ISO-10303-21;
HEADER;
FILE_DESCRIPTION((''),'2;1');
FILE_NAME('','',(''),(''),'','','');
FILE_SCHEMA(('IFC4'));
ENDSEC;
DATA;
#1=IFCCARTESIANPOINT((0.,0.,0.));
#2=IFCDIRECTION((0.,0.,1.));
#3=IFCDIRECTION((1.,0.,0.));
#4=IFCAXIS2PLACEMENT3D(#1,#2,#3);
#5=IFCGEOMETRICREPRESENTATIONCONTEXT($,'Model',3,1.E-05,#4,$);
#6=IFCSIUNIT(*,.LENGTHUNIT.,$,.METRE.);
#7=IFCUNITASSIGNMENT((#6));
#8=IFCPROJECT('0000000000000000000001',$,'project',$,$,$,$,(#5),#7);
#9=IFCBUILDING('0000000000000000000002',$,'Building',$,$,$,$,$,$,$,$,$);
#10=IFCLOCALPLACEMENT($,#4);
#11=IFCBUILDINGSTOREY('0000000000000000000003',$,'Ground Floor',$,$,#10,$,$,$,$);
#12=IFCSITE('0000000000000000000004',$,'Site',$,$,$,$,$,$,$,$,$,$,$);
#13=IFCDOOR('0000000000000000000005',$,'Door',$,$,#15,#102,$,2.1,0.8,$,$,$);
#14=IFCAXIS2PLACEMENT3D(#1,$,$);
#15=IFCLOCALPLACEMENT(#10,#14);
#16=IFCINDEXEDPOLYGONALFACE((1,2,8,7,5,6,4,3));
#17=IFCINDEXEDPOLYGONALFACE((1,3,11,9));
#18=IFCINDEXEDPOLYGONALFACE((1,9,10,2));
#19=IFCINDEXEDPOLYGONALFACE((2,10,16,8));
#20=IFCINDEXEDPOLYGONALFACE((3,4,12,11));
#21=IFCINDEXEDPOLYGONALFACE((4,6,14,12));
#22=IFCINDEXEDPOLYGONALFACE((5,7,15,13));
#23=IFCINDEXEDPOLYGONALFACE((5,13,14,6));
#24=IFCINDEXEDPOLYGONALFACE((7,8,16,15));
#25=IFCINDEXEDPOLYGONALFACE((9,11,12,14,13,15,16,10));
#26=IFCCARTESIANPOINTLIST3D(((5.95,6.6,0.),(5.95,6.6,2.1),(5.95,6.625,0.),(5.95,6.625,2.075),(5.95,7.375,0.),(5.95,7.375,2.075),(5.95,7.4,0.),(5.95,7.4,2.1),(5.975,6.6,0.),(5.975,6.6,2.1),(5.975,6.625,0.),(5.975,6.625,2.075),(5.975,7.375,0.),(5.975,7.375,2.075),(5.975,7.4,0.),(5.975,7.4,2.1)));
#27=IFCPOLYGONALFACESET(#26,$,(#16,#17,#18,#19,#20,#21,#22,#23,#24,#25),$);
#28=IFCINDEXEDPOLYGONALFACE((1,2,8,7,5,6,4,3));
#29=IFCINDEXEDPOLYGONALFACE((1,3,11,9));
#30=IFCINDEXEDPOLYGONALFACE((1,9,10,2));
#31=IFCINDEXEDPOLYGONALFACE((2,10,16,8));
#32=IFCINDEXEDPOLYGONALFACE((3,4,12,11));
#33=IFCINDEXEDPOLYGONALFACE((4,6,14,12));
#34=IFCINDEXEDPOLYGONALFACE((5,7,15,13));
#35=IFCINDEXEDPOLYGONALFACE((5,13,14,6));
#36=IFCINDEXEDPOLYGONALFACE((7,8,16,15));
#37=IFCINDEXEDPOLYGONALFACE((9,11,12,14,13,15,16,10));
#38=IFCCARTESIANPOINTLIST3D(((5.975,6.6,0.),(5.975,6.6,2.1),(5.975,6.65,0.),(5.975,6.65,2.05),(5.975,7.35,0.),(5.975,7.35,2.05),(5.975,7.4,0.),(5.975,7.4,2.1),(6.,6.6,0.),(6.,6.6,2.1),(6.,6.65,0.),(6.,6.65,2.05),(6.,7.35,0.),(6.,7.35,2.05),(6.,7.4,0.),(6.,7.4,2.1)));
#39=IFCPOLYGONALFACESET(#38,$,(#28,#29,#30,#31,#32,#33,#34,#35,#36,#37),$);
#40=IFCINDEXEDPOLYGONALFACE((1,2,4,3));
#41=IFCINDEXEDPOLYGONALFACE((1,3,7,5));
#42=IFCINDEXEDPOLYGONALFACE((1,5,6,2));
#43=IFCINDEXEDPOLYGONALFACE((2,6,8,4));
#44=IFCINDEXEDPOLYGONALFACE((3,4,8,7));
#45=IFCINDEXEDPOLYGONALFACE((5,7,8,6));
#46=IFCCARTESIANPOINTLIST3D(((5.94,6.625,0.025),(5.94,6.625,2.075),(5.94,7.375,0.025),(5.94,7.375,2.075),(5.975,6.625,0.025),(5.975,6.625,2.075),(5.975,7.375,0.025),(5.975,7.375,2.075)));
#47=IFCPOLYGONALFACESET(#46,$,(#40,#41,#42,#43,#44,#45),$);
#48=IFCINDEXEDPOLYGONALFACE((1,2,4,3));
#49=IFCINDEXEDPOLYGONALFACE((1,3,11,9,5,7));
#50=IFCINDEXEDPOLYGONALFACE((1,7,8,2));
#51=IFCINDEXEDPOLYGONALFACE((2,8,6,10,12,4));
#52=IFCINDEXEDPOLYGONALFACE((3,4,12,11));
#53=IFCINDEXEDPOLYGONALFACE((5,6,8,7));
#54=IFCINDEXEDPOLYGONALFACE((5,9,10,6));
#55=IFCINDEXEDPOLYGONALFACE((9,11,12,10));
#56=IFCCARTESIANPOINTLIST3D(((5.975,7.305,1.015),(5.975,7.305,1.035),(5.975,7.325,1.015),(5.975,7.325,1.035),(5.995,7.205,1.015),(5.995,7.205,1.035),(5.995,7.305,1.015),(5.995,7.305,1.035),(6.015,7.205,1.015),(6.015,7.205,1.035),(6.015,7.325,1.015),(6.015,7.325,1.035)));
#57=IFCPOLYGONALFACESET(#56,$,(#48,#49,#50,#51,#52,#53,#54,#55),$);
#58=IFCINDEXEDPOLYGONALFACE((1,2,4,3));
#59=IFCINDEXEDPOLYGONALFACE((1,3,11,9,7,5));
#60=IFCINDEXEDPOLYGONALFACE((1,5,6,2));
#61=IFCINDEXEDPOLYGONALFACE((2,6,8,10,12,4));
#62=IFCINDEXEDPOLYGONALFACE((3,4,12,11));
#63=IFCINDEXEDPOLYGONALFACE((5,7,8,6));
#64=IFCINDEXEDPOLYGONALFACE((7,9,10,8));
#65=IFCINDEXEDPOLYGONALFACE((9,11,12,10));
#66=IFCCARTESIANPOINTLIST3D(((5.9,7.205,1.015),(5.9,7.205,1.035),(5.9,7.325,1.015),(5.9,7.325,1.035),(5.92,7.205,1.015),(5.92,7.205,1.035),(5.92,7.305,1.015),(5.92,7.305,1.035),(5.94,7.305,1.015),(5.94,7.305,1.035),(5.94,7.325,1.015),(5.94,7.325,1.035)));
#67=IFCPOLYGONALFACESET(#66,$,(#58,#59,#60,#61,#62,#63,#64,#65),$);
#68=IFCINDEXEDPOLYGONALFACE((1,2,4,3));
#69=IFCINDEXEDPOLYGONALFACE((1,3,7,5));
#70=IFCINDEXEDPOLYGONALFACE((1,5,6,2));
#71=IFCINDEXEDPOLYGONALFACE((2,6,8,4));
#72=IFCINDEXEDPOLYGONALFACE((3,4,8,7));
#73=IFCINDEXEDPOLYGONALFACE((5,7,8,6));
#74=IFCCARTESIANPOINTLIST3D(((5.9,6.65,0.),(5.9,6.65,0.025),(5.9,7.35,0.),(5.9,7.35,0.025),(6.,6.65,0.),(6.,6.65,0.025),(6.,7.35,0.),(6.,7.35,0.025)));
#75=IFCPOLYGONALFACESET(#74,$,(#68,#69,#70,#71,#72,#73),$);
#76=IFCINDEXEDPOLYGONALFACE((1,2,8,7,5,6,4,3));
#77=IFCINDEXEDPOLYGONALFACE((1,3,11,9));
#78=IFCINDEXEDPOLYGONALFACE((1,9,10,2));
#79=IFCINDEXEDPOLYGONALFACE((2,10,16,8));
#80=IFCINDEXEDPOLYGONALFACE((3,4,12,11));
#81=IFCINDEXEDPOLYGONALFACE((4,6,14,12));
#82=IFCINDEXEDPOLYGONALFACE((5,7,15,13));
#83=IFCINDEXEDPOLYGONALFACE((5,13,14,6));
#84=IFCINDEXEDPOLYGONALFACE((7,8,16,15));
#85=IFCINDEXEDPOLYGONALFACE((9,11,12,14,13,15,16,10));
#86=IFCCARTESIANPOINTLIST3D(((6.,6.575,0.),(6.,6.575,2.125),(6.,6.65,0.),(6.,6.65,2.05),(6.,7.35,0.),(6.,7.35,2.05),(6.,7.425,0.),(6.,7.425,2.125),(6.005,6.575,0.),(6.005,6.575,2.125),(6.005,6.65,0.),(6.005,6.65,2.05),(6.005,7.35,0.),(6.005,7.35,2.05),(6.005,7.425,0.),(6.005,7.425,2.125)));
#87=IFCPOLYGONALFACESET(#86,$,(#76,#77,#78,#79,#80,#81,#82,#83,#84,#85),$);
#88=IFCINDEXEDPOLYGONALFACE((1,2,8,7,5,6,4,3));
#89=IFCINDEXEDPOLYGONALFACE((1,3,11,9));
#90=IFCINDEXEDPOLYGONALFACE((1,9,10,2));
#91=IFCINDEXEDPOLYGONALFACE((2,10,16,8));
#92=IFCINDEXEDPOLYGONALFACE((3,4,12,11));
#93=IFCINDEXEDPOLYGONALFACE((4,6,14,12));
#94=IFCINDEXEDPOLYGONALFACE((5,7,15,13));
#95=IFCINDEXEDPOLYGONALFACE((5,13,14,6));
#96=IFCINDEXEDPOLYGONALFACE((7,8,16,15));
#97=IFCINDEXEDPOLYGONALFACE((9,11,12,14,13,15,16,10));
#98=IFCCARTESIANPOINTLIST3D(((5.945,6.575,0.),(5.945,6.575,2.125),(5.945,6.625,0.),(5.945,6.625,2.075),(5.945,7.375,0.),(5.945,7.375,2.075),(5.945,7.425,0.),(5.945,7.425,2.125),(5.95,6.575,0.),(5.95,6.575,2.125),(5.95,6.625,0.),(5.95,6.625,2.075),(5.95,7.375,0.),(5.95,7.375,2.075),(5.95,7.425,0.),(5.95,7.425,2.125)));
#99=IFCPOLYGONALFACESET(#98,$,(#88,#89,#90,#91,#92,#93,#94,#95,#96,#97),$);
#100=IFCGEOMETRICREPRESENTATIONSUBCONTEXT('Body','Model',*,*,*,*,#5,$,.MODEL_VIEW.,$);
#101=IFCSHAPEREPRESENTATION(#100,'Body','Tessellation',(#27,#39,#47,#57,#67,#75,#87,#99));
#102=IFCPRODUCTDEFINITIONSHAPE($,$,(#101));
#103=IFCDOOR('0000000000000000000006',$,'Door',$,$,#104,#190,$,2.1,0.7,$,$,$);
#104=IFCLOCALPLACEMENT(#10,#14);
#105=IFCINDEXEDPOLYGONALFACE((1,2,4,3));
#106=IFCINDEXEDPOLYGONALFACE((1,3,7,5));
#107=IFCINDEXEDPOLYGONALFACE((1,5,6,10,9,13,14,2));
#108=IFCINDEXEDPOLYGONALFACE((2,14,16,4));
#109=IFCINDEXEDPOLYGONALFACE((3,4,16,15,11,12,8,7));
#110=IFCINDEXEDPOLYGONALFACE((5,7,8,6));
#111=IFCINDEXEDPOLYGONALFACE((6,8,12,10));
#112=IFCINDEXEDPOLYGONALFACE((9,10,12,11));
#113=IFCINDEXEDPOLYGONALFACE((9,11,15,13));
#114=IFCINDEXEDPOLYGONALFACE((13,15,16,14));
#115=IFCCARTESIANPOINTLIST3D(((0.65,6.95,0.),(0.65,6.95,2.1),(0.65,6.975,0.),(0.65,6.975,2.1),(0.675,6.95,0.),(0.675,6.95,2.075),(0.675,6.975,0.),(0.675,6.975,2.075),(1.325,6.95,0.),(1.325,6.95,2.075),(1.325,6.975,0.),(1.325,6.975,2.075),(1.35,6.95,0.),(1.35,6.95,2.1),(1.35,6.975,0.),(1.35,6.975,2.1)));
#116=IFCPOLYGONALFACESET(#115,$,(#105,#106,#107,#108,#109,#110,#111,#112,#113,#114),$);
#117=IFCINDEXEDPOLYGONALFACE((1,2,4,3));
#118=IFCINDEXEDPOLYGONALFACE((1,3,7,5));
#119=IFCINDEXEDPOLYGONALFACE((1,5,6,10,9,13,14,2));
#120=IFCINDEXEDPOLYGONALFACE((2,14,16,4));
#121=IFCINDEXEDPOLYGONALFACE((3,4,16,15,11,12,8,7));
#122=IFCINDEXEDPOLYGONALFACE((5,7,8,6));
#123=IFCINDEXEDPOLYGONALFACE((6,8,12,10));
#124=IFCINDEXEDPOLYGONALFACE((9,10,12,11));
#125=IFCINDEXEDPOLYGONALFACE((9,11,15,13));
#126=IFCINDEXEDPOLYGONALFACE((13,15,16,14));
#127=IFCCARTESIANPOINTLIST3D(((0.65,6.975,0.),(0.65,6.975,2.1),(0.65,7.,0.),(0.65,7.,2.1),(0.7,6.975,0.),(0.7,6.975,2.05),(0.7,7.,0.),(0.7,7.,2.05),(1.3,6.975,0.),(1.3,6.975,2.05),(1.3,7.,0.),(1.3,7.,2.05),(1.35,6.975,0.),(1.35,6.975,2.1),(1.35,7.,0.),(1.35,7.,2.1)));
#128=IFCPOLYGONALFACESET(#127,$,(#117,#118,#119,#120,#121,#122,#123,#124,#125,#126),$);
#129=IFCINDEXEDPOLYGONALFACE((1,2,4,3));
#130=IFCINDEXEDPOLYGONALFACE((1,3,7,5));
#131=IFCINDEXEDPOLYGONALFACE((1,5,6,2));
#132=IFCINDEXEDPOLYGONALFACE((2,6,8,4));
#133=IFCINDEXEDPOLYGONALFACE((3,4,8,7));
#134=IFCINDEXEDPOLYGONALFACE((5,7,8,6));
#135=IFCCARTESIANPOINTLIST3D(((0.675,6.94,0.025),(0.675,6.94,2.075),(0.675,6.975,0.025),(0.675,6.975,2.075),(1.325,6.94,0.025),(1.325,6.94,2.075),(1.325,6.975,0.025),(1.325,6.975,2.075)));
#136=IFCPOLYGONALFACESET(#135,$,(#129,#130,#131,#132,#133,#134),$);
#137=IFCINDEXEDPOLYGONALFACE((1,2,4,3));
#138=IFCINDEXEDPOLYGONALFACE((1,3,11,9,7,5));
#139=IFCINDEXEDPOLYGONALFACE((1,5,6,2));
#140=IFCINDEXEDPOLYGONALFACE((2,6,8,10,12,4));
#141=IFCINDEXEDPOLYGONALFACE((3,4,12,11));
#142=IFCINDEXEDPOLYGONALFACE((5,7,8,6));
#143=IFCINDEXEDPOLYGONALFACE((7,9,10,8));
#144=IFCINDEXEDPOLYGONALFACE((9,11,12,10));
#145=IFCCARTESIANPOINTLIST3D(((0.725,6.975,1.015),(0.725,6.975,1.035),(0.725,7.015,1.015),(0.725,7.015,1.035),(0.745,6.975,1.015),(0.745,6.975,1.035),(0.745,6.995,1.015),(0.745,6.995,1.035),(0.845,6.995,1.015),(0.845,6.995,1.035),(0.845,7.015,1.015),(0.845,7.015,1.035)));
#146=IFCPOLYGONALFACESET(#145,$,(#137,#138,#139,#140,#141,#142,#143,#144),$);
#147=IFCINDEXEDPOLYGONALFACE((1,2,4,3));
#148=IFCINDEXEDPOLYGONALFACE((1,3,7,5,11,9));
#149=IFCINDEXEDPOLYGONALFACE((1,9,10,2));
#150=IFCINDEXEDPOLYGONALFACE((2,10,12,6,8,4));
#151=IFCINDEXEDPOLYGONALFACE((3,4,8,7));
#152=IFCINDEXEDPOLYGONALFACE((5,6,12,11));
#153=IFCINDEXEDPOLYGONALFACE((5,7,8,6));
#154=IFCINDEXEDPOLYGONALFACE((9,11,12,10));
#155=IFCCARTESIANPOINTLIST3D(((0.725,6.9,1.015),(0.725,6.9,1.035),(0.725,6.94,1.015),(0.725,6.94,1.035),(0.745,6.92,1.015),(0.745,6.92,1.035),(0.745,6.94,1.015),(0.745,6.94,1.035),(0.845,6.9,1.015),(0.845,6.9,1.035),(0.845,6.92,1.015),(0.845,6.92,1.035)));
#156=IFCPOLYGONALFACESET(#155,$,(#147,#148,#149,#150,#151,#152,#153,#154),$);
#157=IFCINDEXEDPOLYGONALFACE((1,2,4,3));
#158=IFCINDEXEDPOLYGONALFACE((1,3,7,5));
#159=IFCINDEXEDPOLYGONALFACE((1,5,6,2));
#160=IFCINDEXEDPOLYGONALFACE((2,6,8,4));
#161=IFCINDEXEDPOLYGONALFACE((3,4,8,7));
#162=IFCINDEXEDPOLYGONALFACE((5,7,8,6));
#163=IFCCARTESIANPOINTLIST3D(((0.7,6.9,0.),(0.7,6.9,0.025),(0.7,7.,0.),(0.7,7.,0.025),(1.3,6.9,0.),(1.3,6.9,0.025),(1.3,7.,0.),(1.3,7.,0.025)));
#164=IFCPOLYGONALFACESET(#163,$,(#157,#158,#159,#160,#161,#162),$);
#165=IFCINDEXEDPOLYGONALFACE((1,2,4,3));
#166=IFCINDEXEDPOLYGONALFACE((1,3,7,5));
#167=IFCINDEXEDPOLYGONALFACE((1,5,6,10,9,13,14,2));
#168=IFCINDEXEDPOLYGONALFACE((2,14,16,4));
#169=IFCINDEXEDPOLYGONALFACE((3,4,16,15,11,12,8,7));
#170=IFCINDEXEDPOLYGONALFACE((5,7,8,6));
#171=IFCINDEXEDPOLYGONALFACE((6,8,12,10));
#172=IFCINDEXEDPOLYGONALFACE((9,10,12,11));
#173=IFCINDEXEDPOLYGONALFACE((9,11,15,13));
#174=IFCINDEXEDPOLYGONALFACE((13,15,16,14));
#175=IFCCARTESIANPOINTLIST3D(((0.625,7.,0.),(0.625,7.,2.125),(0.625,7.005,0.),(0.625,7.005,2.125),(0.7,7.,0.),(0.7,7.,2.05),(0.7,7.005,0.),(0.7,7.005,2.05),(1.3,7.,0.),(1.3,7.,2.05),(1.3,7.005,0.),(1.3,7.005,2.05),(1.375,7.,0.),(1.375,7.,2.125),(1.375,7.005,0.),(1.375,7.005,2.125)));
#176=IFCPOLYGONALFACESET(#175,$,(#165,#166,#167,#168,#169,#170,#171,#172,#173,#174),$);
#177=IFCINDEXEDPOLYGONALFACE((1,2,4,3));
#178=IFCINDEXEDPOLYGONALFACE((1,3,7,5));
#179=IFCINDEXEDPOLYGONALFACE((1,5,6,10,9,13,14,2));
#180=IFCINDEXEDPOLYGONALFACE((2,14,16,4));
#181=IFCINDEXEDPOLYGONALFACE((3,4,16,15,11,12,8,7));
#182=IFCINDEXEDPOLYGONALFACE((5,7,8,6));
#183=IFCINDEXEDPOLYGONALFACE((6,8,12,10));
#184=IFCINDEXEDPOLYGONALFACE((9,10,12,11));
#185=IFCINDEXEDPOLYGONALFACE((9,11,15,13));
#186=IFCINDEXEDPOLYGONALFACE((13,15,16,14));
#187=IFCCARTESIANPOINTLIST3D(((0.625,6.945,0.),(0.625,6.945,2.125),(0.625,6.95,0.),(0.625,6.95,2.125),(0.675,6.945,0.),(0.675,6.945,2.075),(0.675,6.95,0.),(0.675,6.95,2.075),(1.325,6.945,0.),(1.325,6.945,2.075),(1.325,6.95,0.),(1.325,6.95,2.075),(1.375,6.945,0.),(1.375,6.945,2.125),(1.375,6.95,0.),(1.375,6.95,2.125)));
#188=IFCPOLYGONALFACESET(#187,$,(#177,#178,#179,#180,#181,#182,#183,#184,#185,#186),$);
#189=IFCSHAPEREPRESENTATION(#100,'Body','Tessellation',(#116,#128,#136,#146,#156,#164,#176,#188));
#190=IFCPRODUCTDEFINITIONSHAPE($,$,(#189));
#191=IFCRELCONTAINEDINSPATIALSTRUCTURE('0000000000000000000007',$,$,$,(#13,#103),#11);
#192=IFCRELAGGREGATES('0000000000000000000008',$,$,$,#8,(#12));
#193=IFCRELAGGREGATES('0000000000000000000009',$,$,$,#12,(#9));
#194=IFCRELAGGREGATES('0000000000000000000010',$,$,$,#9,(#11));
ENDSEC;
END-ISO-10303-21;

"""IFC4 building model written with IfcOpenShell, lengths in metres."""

from ifc_helpers import new_model, si_unit, frame, origin_with_axes, place, context, subcontext, project, spatial, line, indexed_curve, outline, extrude, element, save


model = new_model("IFC4")

# Units and contexts
model_context = context("Model", 3, precision=1e-05, world=origin_with_axes())
body_context = subcontext(model_context, "Body", "Model", "MODEL_VIEW")
ifc_project = project(units=[si_unit("LENGTHUNIT", "METRE")], contexts=[model_context])

# Site, building, storey
site = spatial("IfcSite", under=ifc_project, Name="Site")
building = spatial("IfcBuilding", under=site, Name="Building")
storey_placement = place(None, origin_with_axes())
storey = spatial("IfcBuildingStorey", under=building, at=storey_placement, Name="Ground Floor")

# Doors
door_1_placement = place(storey_placement, frame((6.0, 6.6, 0.0), z_axis=(0.0, 0.0, 1.0), x_axis=(0.0, 1.0, 0.0)))
element("IfcDoor", 1, at=door_1_placement, inside=storey, Name="Door", OverallHeight=2.1, OverallWidth=0.8, context=body_context, shape_type="SweptSolid", body=[
    extrude(outline(indexed_curve([(0.0, 0.0), (0.0, 2.1), (0.8, 2.1), (0.8, 0.0), (0.775, 0.0), (0.775, 2.075), (0.025, 2.075), (0.025, 0.0)], segments=[line(1, 2, 3, 4, 5, 6, 7, 8, 1)])), frame((0.0, 0.025, 0.0), z_axis=(0.0, -1.0, 0.0), x_axis=(1.0, 0.0, 0.0)), (0.0, 0.0, -1.0), 0.025),
    extrude(outline(indexed_curve([(0.0, 0.0), (0.0, 2.1), (0.8, 2.1), (0.8, 0.0), (0.75, 0.0), (0.75, 2.05), (0.05, 2.05), (0.05, 0.0)], segments=[line(1, 2, 3, 4, 5, 6, 7, 8, 1)])), frame((0.0, 0.0, 0.0), z_axis=(0.0, -1.0, 0.0), x_axis=(1.0, 0.0, 0.0)), (0.0, 0.0, -1.0), 0.025),
    extrude(outline(indexed_curve([(0.0, 0.0), (0.75, 0.0), (0.75, 0.035), (0.0, 0.035)], segments=[line(1, 2, 3, 4, 1)])), frame((0.025, 0.025, 0.025), z_axis=(0.0, 0.0, 1.0), x_axis=(1.0, 0.0, 0.0)), (0.0, 0.0, 1.0), 2.05),
    extrude(outline(indexed_curve([(0.0, 0.0), (0.0, -0.04), (-0.12, -0.04), (-0.12, -0.02), (-0.02, -0.02), (-0.02, 0.0)], segments=[line(1, 2, 3, 4, 5, 6, 1)])), frame((0.725, 0.025, 1.015), z_axis=(0.0, 0.0, 1.0), x_axis=(1.0, 0.0, 0.0)), (0.0, 0.0, 1.0), 0.02),
    extrude(outline(indexed_curve([(0.0, 0.0), (0.0, 0.04), (-0.12, 0.04), (-0.12, 0.02), (-0.02, 0.02), (-0.02, 0.0)], segments=[line(1, 2, 3, 4, 5, 6, 1)])), frame((0.725, 0.06, 1.015), z_axis=(0.0, 0.0, 1.0), x_axis=(1.0, 0.0, 0.0)), (0.0, 0.0, 1.0), 0.02),
    extrude(outline(indexed_curve([(0.0, 0.0), (0.7, 0.0), (0.7, 0.1), (0.0, 0.1)], segments=[line(1, 2, 3, 4, 1)])), frame((0.05, 0.0, 0.0), z_axis=(0.0, 0.0, 1.0), x_axis=(1.0, 0.0, 0.0)), (0.0, 0.0, 1.0), 0.025),
    extrude(outline(indexed_curve([(0.0, 0.0), (0.0, 2.125), (0.85, 2.125), (0.85, 0.0), (0.775, 0.0), (0.775, 2.05), (0.075, 2.05), (0.075, 0.0)], segments=[line(1, 2, 3, 4, 5, 6, 7, 8, 1)])), frame((-0.025, -0.005, 0.0), z_axis=(0.0, -1.0, 0.0), x_axis=(1.0, 0.0, 0.0)), (0.0, 0.0, -1.0), 0.005),
    extrude(outline(indexed_curve([(0.0, 0.0), (0.0, 2.125), (0.85, 2.125), (0.85, 0.0), (0.8, 0.0), (0.8, 2.075), (0.05, 2.075), (0.05, 0.0)], segments=[line(1, 2, 3, 4, 5, 6, 7, 8, 1)])), frame((-0.025, 0.05, 0.0), z_axis=(0.0, -1.0, 0.0), x_axis=(1.0, 0.0, 0.0)), (0.0, 0.0, -1.0), 0.005),
])
door_2_placement = place(storey_placement, frame((1.35, 7.0, 0.0), z_axis=(0.0, 0.0, 1.0), x_axis=(-1.0, 0.0, 0.0)))
element("IfcDoor", 2, at=door_2_placement, inside=storey, Name="Door", OverallHeight=2.1, OverallWidth=0.7, context=body_context, shape_type="SweptSolid", body=[
    extrude(outline(indexed_curve([(0.0, 0.0), (0.0, 2.1), (0.7, 2.1), (0.7, 0.0), (0.675, 0.0), (0.675, 2.075), (0.025, 2.075), (0.025, 0.0)], segments=[line(1, 2, 3, 4, 5, 6, 7, 8, 1)])), frame((0.0, 0.025, 0.0), z_axis=(0.0, -1.0, 0.0), x_axis=(1.0, 0.0, 0.0)), (0.0, 0.0, -1.0), 0.025),
    extrude(outline(indexed_curve([(0.0, 0.0), (0.0, 2.1), (0.7, 2.1), (0.7, 0.0), (0.65, 0.0), (0.65, 2.05), (0.05, 2.05), (0.05, 0.0)], segments=[line(1, 2, 3, 4, 5, 6, 7, 8, 1)])), frame((0.0, 0.0, 0.0), z_axis=(0.0, -1.0, 0.0), x_axis=(1.0, 0.0, 0.0)), (0.0, 0.0, -1.0), 0.025),
    extrude(outline(indexed_curve([(0.0, 0.0), (0.65, 0.0), (0.65, 0.035), (0.0, 0.035)], segments=[line(1, 2, 3, 4, 1)])), frame((0.025, 0.025, 0.025), z_axis=(0.0, 0.0, 1.0), x_axis=(1.0, 0.0, 0.0)), (0.0, 0.0, 1.0), 2.05),
    extrude(outline(indexed_curve([(0.0, 0.0), (0.0, -0.04), (-0.12, -0.04), (-0.12, -0.02), (-0.02, -0.02), (-0.02, 0.0)], segments=[line(1, 2, 3, 4, 5, 6, 1)])), frame((0.625, 0.025, 1.015), z_axis=(0.0, 0.0, 1.0), x_axis=(1.0, 0.0, 0.0)), (0.0, 0.0, 1.0), 0.02),
    extrude(outline(indexed_curve([(0.0, 0.0), (0.0, 0.04), (-0.12, 0.04), (-0.12, 0.02), (-0.02, 0.02), (-0.02, 0.0)], segments=[line(1, 2, 3, 4, 5, 6, 1)])), frame((0.625, 0.06, 1.015), z_axis=(0.0, 0.0, 1.0), x_axis=(1.0, 0.0, 0.0)), (0.0, 0.0, 1.0), 0.02),
    extrude(outline(indexed_curve([(0.0, 0.0), (0.6, 0.0), (0.6, 0.1), (0.0, 0.1)], segments=[line(1, 2, 3, 4, 1)])), frame((0.05, 0.0, 0.0), z_axis=(0.0, 0.0, 1.0), x_axis=(1.0, 0.0, 0.0)), (0.0, 0.0, 1.0), 0.025),
    extrude(outline(indexed_curve([(0.0, 0.0), (0.0, 2.125), (0.75, 2.125), (0.75, 0.0), (0.675, 0.0), (0.675, 2.05), (0.075, 2.05), (0.075, 0.0)], segments=[line(1, 2, 3, 4, 5, 6, 7, 8, 1)])), frame((-0.025, -0.005, 0.0), z_axis=(0.0, -1.0, 0.0), x_axis=(1.0, 0.0, 0.0)), (0.0, 0.0, -1.0), 0.005),
    extrude(outline(indexed_curve([(0.0, 0.0), (0.0, 2.125), (0.75, 2.125), (0.75, 0.0), (0.7, 0.0), (0.7, 2.075), (0.05, 2.075), (0.05, 0.0)], segments=[line(1, 2, 3, 4, 5, 6, 7, 8, 1)])), frame((-0.025, 0.05, 0.0), z_axis=(0.0, -1.0, 0.0), x_axis=(1.0, 0.0, 0.0)), (0.0, 0.0, -1.0), 0.005),
])

save(model, "model.ifc")
